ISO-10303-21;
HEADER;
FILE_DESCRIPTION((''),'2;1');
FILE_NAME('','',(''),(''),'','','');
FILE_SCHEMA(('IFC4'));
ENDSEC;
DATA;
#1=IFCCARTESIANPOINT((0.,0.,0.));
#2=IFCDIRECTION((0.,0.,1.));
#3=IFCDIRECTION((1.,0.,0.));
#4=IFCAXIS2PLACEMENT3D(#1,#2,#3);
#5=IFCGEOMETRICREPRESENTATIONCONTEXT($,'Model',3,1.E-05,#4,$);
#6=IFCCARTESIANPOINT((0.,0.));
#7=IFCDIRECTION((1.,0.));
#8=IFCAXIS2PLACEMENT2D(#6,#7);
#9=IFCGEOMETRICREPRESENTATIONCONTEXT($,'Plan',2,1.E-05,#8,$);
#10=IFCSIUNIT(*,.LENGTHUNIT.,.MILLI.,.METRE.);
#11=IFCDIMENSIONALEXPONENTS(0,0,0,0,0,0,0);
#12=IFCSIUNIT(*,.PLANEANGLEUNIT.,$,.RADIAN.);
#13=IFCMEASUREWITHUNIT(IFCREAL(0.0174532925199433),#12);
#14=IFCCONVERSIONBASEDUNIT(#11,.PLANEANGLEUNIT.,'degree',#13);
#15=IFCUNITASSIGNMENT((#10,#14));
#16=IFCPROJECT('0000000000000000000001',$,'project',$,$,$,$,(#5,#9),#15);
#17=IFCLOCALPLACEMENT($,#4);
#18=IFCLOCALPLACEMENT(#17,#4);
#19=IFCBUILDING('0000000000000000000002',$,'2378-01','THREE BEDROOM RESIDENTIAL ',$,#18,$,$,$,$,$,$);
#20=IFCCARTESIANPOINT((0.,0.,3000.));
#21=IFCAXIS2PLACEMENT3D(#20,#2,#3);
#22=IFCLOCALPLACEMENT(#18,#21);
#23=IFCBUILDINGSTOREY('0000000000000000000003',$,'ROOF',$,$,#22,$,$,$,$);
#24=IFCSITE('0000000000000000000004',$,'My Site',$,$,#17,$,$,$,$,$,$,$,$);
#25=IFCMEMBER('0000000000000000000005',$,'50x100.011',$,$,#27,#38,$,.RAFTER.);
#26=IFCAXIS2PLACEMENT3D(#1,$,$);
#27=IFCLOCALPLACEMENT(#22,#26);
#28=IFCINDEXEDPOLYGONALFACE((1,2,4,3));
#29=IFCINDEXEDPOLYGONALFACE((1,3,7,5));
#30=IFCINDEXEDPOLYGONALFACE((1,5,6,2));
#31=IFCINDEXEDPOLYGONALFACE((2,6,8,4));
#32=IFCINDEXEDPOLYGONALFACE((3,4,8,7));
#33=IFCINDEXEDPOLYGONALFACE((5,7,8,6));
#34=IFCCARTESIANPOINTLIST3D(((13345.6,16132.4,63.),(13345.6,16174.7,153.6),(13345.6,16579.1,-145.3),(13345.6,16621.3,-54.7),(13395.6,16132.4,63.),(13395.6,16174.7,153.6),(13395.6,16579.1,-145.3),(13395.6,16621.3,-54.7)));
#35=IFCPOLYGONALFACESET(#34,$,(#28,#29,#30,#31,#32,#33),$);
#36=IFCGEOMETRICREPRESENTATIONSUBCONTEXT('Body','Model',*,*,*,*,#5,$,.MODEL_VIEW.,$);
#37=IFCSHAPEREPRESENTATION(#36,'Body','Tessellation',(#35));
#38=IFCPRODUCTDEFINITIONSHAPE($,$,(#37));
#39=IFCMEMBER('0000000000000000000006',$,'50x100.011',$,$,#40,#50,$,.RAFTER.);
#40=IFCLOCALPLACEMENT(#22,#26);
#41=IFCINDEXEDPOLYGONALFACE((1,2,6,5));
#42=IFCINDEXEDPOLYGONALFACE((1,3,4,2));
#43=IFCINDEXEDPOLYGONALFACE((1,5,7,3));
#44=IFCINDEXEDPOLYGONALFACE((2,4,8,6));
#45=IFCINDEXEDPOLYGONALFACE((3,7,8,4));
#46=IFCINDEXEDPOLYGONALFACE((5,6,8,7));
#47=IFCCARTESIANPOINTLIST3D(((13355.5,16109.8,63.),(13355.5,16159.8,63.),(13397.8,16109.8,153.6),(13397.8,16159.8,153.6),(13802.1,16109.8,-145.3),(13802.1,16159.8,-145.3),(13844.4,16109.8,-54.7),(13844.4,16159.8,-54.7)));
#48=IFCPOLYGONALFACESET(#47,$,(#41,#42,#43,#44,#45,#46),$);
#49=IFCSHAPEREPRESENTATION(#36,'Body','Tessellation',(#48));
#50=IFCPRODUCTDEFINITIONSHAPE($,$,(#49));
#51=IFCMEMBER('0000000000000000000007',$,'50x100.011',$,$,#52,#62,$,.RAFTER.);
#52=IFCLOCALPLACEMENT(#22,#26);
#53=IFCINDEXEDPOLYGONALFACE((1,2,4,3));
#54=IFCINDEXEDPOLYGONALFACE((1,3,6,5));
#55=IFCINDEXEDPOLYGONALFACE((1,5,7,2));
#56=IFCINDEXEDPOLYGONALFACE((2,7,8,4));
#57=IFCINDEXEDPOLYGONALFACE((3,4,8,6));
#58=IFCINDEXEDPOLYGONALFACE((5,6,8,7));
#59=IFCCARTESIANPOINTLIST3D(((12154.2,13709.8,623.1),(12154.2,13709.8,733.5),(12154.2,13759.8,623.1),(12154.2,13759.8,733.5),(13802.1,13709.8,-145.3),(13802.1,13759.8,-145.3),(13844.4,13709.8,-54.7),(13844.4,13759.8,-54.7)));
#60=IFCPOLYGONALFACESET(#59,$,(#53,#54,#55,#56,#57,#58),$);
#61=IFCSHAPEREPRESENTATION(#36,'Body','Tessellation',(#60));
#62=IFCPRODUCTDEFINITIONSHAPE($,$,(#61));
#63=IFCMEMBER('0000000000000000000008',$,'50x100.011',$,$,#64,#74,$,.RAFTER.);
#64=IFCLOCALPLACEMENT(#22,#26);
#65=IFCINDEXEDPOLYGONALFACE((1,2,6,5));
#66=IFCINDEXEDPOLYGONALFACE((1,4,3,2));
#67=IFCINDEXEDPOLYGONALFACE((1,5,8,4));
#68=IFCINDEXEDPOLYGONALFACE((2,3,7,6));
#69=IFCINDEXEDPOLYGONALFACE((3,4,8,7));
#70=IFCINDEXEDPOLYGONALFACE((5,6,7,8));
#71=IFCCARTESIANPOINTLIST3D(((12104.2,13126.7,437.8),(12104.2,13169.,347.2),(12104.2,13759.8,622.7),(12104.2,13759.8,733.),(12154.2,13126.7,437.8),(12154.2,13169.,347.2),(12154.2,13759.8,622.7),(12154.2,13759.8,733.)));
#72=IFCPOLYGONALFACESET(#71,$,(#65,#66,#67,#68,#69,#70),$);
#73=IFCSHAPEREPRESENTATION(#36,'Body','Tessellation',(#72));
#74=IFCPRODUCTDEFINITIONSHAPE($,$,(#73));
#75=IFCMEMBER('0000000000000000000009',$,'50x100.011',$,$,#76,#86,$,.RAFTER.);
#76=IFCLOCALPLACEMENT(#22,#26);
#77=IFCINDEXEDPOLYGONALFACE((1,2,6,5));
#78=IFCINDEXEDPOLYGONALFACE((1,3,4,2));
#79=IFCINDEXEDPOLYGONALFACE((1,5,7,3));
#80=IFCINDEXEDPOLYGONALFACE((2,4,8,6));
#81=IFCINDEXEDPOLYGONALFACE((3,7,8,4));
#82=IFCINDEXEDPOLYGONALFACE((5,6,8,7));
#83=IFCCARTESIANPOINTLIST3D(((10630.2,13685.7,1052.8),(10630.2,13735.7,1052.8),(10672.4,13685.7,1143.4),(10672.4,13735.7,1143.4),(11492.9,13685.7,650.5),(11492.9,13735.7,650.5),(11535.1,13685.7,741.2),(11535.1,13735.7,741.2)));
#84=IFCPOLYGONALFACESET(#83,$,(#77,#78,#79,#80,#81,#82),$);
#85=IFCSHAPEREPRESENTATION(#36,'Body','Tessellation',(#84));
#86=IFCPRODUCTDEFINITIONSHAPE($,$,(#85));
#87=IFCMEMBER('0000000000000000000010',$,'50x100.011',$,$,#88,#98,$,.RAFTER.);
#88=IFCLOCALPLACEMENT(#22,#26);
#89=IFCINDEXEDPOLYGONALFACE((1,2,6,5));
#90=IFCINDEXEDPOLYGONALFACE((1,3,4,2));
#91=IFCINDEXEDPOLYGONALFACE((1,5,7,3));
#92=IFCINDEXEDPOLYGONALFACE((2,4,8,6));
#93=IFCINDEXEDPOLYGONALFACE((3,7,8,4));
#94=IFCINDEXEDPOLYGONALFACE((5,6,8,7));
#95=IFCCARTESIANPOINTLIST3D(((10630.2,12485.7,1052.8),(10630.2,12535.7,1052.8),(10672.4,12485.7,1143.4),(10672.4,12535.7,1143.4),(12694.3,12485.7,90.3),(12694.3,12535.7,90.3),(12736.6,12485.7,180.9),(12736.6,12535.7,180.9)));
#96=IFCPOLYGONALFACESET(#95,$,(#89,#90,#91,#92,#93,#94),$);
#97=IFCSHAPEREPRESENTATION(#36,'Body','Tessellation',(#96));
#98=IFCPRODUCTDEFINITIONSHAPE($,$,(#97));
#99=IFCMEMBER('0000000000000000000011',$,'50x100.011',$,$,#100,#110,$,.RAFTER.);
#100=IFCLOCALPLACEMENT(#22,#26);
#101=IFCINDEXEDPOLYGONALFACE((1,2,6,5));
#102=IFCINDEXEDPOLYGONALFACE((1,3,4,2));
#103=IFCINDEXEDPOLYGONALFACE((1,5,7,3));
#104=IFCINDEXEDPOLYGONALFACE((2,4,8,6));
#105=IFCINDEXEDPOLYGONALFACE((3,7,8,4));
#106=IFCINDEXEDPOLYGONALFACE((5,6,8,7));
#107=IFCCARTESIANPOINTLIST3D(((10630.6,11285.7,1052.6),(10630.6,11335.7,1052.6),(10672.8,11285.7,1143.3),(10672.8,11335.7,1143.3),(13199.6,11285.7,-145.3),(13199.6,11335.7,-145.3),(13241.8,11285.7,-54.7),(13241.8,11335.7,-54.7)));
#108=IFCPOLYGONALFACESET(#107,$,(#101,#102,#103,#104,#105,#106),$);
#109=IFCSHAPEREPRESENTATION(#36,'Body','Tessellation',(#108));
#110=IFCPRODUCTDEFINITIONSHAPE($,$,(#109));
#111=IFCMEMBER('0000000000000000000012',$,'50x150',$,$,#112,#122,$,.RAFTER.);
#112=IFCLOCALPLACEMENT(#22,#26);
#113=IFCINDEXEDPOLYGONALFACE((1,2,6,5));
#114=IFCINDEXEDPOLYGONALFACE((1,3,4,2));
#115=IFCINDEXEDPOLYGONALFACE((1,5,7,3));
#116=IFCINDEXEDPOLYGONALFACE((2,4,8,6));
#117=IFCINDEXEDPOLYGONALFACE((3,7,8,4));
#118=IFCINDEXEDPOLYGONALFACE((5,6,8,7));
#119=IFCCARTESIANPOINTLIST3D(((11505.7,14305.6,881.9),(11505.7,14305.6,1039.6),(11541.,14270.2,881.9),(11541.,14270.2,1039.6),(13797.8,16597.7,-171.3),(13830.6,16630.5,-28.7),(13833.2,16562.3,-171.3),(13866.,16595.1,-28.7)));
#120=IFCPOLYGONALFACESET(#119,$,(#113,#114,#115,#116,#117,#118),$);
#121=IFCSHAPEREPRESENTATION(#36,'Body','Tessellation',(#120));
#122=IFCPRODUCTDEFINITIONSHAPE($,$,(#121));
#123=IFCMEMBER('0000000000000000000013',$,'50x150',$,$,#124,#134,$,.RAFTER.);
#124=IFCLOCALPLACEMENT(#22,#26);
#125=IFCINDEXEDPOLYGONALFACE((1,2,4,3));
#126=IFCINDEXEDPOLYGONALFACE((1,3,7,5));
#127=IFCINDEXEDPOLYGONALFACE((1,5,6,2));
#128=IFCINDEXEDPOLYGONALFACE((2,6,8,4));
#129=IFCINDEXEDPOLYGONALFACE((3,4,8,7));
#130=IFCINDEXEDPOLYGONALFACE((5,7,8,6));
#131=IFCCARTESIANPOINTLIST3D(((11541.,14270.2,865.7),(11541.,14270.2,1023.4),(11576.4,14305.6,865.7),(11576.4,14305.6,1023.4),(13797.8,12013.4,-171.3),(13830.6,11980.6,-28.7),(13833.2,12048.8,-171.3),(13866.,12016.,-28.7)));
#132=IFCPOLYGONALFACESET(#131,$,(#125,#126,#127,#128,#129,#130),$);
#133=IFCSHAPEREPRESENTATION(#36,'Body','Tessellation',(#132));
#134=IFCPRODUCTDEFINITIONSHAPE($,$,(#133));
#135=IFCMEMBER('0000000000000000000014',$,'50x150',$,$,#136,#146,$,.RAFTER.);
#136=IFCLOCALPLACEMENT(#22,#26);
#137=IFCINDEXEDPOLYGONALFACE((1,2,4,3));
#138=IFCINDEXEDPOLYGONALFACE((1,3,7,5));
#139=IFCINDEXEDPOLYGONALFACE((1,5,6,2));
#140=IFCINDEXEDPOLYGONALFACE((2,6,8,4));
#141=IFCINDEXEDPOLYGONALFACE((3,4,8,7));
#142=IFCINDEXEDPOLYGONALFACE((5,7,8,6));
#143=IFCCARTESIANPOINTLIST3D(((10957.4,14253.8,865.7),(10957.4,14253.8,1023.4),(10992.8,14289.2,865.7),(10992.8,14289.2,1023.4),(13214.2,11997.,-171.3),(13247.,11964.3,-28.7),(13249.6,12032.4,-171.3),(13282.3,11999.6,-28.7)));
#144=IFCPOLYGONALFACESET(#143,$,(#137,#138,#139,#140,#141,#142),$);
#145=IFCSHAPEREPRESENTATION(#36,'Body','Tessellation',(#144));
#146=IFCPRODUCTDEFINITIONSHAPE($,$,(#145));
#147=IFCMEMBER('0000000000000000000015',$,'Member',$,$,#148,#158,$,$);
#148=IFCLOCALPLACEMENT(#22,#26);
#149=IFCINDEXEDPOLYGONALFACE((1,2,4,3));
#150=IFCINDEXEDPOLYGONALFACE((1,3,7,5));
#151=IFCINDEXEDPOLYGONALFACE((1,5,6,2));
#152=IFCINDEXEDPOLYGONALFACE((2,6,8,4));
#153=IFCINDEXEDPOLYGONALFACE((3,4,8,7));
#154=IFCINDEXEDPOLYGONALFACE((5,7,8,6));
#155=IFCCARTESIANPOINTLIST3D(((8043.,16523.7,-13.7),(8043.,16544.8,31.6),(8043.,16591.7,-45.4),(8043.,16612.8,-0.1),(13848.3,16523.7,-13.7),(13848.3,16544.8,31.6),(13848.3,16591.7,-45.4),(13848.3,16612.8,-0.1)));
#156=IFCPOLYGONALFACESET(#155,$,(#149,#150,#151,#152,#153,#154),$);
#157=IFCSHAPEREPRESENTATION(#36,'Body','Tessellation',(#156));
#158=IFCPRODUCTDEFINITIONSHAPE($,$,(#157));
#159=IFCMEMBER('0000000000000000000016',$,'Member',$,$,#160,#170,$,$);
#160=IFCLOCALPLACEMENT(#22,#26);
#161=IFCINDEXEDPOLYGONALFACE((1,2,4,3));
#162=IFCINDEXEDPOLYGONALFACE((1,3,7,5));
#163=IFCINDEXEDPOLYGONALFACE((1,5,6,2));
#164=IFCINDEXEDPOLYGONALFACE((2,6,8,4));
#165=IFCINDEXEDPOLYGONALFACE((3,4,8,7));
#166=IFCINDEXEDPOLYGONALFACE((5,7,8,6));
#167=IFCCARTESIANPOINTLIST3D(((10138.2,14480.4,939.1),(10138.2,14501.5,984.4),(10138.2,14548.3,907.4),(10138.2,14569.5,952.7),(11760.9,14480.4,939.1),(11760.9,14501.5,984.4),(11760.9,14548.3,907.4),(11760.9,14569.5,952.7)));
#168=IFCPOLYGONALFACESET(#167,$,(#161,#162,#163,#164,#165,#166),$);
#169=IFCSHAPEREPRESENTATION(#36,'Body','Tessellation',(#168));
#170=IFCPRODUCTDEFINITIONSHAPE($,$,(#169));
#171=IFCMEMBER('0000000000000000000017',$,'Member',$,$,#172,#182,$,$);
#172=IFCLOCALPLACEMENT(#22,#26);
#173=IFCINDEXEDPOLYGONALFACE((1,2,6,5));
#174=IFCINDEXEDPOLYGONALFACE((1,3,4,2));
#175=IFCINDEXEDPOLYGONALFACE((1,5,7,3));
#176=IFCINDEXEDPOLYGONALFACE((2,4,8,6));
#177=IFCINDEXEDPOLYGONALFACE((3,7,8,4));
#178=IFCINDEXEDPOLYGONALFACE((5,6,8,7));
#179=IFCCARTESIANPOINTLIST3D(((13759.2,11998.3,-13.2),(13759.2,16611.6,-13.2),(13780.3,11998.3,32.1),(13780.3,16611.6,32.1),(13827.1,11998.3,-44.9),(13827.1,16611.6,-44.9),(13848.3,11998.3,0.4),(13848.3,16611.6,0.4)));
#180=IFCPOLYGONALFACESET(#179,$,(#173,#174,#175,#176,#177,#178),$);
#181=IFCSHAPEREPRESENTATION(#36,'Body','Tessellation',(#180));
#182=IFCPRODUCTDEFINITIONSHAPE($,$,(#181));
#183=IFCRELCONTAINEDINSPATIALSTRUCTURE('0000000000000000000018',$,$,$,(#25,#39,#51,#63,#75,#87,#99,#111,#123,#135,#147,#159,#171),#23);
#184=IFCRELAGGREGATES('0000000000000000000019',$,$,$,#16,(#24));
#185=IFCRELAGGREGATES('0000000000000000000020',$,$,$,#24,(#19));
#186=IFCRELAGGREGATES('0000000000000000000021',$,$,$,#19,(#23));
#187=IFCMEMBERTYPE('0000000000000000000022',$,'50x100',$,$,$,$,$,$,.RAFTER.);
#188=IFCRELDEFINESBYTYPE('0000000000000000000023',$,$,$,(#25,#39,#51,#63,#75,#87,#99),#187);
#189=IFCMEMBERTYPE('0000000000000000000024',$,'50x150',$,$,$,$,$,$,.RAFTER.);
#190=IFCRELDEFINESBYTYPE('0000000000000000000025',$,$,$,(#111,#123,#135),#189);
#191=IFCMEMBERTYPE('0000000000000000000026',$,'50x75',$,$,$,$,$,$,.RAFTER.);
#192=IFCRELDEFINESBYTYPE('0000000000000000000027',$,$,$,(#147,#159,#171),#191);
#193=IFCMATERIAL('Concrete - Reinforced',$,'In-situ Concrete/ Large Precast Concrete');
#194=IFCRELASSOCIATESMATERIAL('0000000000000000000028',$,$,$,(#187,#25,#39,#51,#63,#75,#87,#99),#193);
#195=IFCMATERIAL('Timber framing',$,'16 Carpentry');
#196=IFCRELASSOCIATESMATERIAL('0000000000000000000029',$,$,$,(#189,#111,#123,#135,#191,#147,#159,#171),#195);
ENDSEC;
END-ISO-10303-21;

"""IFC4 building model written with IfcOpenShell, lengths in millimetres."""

from ifc_helpers import new_model, entity, si_unit, converted_unit, frame, origin_with_axes, origin_2d_with_axis, place, context, subcontext, project, spatial, rectangle, extrude, clip, halfspace, material, material_profile, profile_set, profile_usage, type_object, element, save


model = new_model("IFC4")

# Units and contexts
model_context = context("Model", 3, precision=1e-05, world=origin_with_axes())
plan_context = context("Plan", 2, precision=1e-05, world=origin_2d_with_axis())
body_context = subcontext(model_context, "Body", "Model", "MODEL_VIEW")
ifc_project = project(units=[si_unit("LENGTHUNIT", "METRE", prefix="MILLI"), converted_unit("PLANEANGLEUNIT", "degree", entity("IfcReal", 0.0174532925199433), si_unit("PLANEANGLEUNIT", "RADIAN"), dimensions=[0, 0, 0, 0, 0, 0, 0])], contexts=[model_context, plan_context])

# Site, building, storey
site_placement = place(None, origin_with_axes())
site = spatial("IfcSite", under=ifc_project, at=site_placement, Name="My Site")
building_placement = place(site_placement, origin_with_axes())
building = spatial("IfcBuilding", under=site, at=building_placement, Name="2378-01", Description="THREE BEDROOM RESIDENTIAL ")
storey_placement = place(building_placement, frame((0.0, 0.0, 3000.0), z_axis=(0.0, 0.0, 1.0), x_axis=(1.0, 0.0, 0.0)))
storey = spatial("IfcBuildingStorey", under=building, at=storey_placement, Name="ROOF")

# Members
ifc_material_1 = material(Name="Concrete - Reinforced", Category="In-situ Concrete/ Large Precast Concrete")
ifc_material_profile_1 = material_profile(ifc_material_1, rectangle(XDim=50.0, YDim=100.0), Name="Core Layer", Category="LoadBearing", Priority=1)
ifc_profile_set_1 = profile_set([ifc_material_profile_1], Name="wood")
ifc_profile_usage_1 = profile_usage(ifc_profile_set_1)
member_type_1 = type_object("IfcMemberType", Name="50x100", PredefinedType="RAFTER", material=ifc_profile_set_1)
member_1_placement = place(storey_placement, frame((13370.6, 16600.2, -100.0), z_axis=(0.0, -0.906308, 0.422618), x_axis=(1.0, 0.0, 0.0)))
element("IfcMember", 1, at=member_1_placement, inside=storey, type_object=member_type_1, material=ifc_profile_usage_1, Name="50x100.011", PredefinedType="RAFTER", context=body_context, shape_type="SweptSolid", body=[
    extrude(rectangle(XDim=50.0, YDim=100.0), origin_with_axes(), (0.0, 0.0, 1.0), 492.8),
])
ifc_profile_usage_2 = profile_usage(ifc_profile_set_1)
member_2_placement = place(storey_placement, frame((13823.3, 16134.8, -100.0), z_axis=(-0.906308, 0.0, 0.422618), x_axis=(0.0, -1.0, 0.0)))
element("IfcMember", 2, at=member_2_placement, inside=storey, type_object=member_type_1, material=ifc_profile_usage_2, Name="50x100.011", PredefinedType="RAFTER", context=body_context, shape_type="SweptSolid", body=[
    extrude(rectangle(XDim=50.0, YDim=100.0), origin_with_axes(), (0.0, 0.0, 1.0), 492.8),
])
ifc_profile_usage_3 = profile_usage(ifc_profile_set_1)
member_3_placement = place(storey_placement, frame((13823.3, 13734.8, -100.0), z_axis=(-0.906308, 0.0, 0.422618), x_axis=(0.0, -1.0, 0.0)))
element("IfcMember", 3, at=member_3_placement, inside=storey, type_object=member_type_1, material=ifc_profile_usage_3, Name="50x100.011", PredefinedType="RAFTER", context=body_context, shape_type="Clipping", body=[
    clip(extrude(rectangle(XDim=50.0, YDim=100.0), origin_with_axes(), (0.0, 0.0, 1.0), 1941.6), halfspace(frame((586.9, -259.0, 1720.8), z_axis=(0.0, -0.422618, 0.906308), x_axis=(-1.0, 0.000001, 0.0)), False)),
])
ifc_profile_usage_4 = profile_usage(ifc_profile_set_1)
member_4_placement = place(storey_placement, frame((12129.2, 13147.8, 392.5), z_axis=(0.0, 0.906308, 0.422618), x_axis=(-1.0, 0.0, 0.0)))
element("IfcMember", 4, at=member_4_placement, inside=storey, type_object=member_type_1, material=ifc_profile_usage_4, Name="50x100.011", PredefinedType="RAFTER", context=body_context, shape_type="Clipping", body=[
    clip(extrude(rectangle(XDim=50.0, YDim=100.0), origin_with_axes(), (0.0, 0.0, 1.0), 775.2), halfspace(frame((-1694.1, -705.0, 346.5), z_axis=(0.0, -0.422618, 0.906308), x_axis=(-1.0, -0.000001, 0.0)), False)),
])
ifc_profile_usage_5 = profile_usage(ifc_profile_set_1, cardinal=5)
member_5_placement = place(storey_placement, frame((11514.0, 13710.7, 695.8), z_axis=(-0.906308, 0.0, 0.422618), x_axis=(0.0, -1.0, 0.0)))
element("IfcMember", 5, at=member_5_placement, inside=storey, type_object=member_type_1, material=ifc_profile_usage_5, Name="50x100.011", PredefinedType="RAFTER", context=body_context, shape_type="SweptSolid", body=[
    extrude(rectangle(XDim=50.0, YDim=100.0), origin_with_axes(), (0.0, 0.0, 1.0), 951.9),
])
ifc_profile_usage_6 = profile_usage(ifc_profile_set_1, cardinal=5)
member_6_placement = place(storey_placement, frame((12715.4, 12510.7, 135.6), z_axis=(-0.906308, 0.0, 0.422618), x_axis=(0.0, -1.0, 0.0)))
element("IfcMember", 6, at=member_6_placement, inside=storey, type_object=member_type_1, material=ifc_profile_usage_6, Name="50x100.011", PredefinedType="RAFTER", context=body_context, shape_type="SweptSolid", body=[
    extrude(rectangle(XDim=50.0, YDim=100.0), origin_with_axes(), (0.0, 0.0, 1.0), 2277.5),
])
ifc_profile_usage_7 = profile_usage(ifc_profile_set_1, cardinal=5)
member_7_placement = place(storey_placement, frame((13220.7, 11310.7, -100.0), z_axis=(-0.906308, 0.0, 0.422618), x_axis=(0.0, -1.0, 0.0)))
element("IfcMember", 7, at=member_7_placement, inside=storey, type_object=member_type_1, material=ifc_profile_usage_7, Name="50x100.011", PredefinedType="RAFTER", context=body_context, shape_type="SweptSolid", body=[
    extrude(rectangle(XDim=50.0, YDim=100.0), origin_with_axes(), (0.0, 0.0, 1.0), 2834.6),
])
ifc_material_2 = material(Name="Timber framing", Category="16 Carpentry")
ifc_material_profile_2 = material_profile(ifc_material_2, rectangle(XDim=50.0, YDim=150.0), Name="Lumber", Category="LoadBearing", Priority=1)
ifc_profile_set_2 = profile_set([ifc_material_profile_2], Name="wood")
ifc_profile_usage_8 = profile_usage(ifc_profile_set_2)
member_type_2 = type_object("IfcMemberType", Name="50x150", PredefinedType="RAFTER", material=ifc_profile_set_2)
member_8_placement = place(storey_placement, frame((13831.9, 16596.4, -100.0), z_axis=(-0.672499, -0.672498, 0.309017), x_axis=(0.707107, -0.707107, 0.0)))
element("IfcMember", 8, at=member_8_placement, inside=storey, type_object=member_type_2, material=ifc_profile_usage_8, Name="50x150", PredefinedType="RAFTER", context=body_context, shape_type="Clipping", body=[
    clip(extrude(rectangle(XDim=50.0, YDim=150.0), origin_with_axes(), (0.0, 0.0, 1.0), 3582.8), halfspace(frame((3239.7, -1008.9, 3105.0), z_axis=(0.0, -0.309017, 0.951056), x_axis=(-1.0, 0.0, 0.0)), False)),
])
ifc_profile_usage_9 = profile_usage(ifc_profile_set_2)
member_9_placement = place(storey_placement, frame((13831.9, 12014.7, -100.0), z_axis=(-0.672498, 0.672499, 0.309017), x_axis=(-0.707107, -0.707107, 0.0)))
element("IfcMember", 9, at=member_9_placement, inside=storey, type_object=member_type_2, material=ifc_profile_usage_9, Name="50x150", PredefinedType="RAFTER", context=body_context, shape_type="Clipping", body=[
    clip(extrude(rectangle(XDim=50.0, YDim=150.0), origin_with_axes(), (0.0, 0.0, 1.0), 3530.2), halfspace(frame((-3239.7, -993.4, 3057.4), z_axis=(0.0, -0.309017, 0.951056), x_axis=(-1.0, -0.000001, 0.0)), False)),
])
ifc_profile_usage_10 = profile_usage(ifc_profile_set_2)
member_10_placement = place(storey_placement, frame((13248.3, 11998.3, -100.0), z_axis=(-0.672498, 0.672499, 0.309017), x_axis=(-0.707107, -0.707107, 0.0)))
element("IfcMember", 10, at=member_10_placement, inside=storey, type_object=member_type_2, material=ifc_profile_usage_10, Name="50x150", PredefinedType="RAFTER", context=body_context, shape_type="Clipping", body=[
    clip(extrude(rectangle(XDim=50.0, YDim=150.0), origin_with_axes(), (0.0, 0.0, 1.0), 3530.2), halfspace(frame((-3239.7, -993.4, 3057.4), z_axis=(0.0, -0.309017, 0.951056), x_axis=(-1.0, -0.000001, 0.0)), False)),
])
ifc_material_profile_3 = material_profile(ifc_material_2, rectangle(XDim=50.0, YDim=75.0), Name="Lumber2", Category="Substrate", Priority=2)
ifc_profile_set_3 = profile_set([ifc_material_profile_3])
ifc_profile_usage_11 = profile_usage(ifc_profile_set_3, cardinal=5)
member_type_3 = type_object("IfcMemberType", Name="50x75", PredefinedType="RAFTER", material=ifc_profile_set_3)
member_11_placement = place(storey_placement, frame((13848.3, 16568.2, -6.9), z_axis=(-1.0, 0.0, 0.0), x_axis=(0.0, -0.422618, -0.906308)))
element("IfcMember", 11, at=member_11_placement, inside=storey, type_object=member_type_3, material=ifc_profile_usage_11, Name="Member", context=body_context, shape_type="SweptSolid", body=[
    extrude(rectangle(XDim=50.0, YDim=75.0), origin_with_axes(), (0.0, 0.0, 1.0), 5805.3),
])
ifc_profile_usage_12 = profile_usage(ifc_profile_set_3, cardinal=5)
member_12_placement = place(storey_placement, frame((11760.9, 14524.9, 945.9), z_axis=(-1.0, 0.0, 0.0), x_axis=(0.0, -0.422618, -0.906308)))
element("IfcMember", 12, at=member_12_placement, inside=storey, type_object=member_type_3, material=ifc_profile_usage_12, Name="Member", context=body_context, shape_type="SweptSolid", body=[
    extrude(rectangle(XDim=50.0, YDim=75.0), origin_with_axes(), (0.0, 0.0, 1.0), 1622.7),
])
ifc_profile_usage_13 = profile_usage(ifc_profile_set_3, cardinal=5)
member_13_placement = place(storey_placement, frame((13803.7, 11998.3, -6.4), z_axis=(0.0, 1.0, 0.0), x_axis=(-0.422618, 0.0, -0.906308)))
element("IfcMember", 13, at=member_13_placement, inside=storey, type_object=member_type_3, material=ifc_profile_usage_13, Name="Member", context=body_context, shape_type="SweptSolid", body=[
    extrude(rectangle(XDim=50.0, YDim=75.0), origin_with_axes(), (0.0, 0.0, 1.0), 4613.3),
])

save(model, "model.ifc")
